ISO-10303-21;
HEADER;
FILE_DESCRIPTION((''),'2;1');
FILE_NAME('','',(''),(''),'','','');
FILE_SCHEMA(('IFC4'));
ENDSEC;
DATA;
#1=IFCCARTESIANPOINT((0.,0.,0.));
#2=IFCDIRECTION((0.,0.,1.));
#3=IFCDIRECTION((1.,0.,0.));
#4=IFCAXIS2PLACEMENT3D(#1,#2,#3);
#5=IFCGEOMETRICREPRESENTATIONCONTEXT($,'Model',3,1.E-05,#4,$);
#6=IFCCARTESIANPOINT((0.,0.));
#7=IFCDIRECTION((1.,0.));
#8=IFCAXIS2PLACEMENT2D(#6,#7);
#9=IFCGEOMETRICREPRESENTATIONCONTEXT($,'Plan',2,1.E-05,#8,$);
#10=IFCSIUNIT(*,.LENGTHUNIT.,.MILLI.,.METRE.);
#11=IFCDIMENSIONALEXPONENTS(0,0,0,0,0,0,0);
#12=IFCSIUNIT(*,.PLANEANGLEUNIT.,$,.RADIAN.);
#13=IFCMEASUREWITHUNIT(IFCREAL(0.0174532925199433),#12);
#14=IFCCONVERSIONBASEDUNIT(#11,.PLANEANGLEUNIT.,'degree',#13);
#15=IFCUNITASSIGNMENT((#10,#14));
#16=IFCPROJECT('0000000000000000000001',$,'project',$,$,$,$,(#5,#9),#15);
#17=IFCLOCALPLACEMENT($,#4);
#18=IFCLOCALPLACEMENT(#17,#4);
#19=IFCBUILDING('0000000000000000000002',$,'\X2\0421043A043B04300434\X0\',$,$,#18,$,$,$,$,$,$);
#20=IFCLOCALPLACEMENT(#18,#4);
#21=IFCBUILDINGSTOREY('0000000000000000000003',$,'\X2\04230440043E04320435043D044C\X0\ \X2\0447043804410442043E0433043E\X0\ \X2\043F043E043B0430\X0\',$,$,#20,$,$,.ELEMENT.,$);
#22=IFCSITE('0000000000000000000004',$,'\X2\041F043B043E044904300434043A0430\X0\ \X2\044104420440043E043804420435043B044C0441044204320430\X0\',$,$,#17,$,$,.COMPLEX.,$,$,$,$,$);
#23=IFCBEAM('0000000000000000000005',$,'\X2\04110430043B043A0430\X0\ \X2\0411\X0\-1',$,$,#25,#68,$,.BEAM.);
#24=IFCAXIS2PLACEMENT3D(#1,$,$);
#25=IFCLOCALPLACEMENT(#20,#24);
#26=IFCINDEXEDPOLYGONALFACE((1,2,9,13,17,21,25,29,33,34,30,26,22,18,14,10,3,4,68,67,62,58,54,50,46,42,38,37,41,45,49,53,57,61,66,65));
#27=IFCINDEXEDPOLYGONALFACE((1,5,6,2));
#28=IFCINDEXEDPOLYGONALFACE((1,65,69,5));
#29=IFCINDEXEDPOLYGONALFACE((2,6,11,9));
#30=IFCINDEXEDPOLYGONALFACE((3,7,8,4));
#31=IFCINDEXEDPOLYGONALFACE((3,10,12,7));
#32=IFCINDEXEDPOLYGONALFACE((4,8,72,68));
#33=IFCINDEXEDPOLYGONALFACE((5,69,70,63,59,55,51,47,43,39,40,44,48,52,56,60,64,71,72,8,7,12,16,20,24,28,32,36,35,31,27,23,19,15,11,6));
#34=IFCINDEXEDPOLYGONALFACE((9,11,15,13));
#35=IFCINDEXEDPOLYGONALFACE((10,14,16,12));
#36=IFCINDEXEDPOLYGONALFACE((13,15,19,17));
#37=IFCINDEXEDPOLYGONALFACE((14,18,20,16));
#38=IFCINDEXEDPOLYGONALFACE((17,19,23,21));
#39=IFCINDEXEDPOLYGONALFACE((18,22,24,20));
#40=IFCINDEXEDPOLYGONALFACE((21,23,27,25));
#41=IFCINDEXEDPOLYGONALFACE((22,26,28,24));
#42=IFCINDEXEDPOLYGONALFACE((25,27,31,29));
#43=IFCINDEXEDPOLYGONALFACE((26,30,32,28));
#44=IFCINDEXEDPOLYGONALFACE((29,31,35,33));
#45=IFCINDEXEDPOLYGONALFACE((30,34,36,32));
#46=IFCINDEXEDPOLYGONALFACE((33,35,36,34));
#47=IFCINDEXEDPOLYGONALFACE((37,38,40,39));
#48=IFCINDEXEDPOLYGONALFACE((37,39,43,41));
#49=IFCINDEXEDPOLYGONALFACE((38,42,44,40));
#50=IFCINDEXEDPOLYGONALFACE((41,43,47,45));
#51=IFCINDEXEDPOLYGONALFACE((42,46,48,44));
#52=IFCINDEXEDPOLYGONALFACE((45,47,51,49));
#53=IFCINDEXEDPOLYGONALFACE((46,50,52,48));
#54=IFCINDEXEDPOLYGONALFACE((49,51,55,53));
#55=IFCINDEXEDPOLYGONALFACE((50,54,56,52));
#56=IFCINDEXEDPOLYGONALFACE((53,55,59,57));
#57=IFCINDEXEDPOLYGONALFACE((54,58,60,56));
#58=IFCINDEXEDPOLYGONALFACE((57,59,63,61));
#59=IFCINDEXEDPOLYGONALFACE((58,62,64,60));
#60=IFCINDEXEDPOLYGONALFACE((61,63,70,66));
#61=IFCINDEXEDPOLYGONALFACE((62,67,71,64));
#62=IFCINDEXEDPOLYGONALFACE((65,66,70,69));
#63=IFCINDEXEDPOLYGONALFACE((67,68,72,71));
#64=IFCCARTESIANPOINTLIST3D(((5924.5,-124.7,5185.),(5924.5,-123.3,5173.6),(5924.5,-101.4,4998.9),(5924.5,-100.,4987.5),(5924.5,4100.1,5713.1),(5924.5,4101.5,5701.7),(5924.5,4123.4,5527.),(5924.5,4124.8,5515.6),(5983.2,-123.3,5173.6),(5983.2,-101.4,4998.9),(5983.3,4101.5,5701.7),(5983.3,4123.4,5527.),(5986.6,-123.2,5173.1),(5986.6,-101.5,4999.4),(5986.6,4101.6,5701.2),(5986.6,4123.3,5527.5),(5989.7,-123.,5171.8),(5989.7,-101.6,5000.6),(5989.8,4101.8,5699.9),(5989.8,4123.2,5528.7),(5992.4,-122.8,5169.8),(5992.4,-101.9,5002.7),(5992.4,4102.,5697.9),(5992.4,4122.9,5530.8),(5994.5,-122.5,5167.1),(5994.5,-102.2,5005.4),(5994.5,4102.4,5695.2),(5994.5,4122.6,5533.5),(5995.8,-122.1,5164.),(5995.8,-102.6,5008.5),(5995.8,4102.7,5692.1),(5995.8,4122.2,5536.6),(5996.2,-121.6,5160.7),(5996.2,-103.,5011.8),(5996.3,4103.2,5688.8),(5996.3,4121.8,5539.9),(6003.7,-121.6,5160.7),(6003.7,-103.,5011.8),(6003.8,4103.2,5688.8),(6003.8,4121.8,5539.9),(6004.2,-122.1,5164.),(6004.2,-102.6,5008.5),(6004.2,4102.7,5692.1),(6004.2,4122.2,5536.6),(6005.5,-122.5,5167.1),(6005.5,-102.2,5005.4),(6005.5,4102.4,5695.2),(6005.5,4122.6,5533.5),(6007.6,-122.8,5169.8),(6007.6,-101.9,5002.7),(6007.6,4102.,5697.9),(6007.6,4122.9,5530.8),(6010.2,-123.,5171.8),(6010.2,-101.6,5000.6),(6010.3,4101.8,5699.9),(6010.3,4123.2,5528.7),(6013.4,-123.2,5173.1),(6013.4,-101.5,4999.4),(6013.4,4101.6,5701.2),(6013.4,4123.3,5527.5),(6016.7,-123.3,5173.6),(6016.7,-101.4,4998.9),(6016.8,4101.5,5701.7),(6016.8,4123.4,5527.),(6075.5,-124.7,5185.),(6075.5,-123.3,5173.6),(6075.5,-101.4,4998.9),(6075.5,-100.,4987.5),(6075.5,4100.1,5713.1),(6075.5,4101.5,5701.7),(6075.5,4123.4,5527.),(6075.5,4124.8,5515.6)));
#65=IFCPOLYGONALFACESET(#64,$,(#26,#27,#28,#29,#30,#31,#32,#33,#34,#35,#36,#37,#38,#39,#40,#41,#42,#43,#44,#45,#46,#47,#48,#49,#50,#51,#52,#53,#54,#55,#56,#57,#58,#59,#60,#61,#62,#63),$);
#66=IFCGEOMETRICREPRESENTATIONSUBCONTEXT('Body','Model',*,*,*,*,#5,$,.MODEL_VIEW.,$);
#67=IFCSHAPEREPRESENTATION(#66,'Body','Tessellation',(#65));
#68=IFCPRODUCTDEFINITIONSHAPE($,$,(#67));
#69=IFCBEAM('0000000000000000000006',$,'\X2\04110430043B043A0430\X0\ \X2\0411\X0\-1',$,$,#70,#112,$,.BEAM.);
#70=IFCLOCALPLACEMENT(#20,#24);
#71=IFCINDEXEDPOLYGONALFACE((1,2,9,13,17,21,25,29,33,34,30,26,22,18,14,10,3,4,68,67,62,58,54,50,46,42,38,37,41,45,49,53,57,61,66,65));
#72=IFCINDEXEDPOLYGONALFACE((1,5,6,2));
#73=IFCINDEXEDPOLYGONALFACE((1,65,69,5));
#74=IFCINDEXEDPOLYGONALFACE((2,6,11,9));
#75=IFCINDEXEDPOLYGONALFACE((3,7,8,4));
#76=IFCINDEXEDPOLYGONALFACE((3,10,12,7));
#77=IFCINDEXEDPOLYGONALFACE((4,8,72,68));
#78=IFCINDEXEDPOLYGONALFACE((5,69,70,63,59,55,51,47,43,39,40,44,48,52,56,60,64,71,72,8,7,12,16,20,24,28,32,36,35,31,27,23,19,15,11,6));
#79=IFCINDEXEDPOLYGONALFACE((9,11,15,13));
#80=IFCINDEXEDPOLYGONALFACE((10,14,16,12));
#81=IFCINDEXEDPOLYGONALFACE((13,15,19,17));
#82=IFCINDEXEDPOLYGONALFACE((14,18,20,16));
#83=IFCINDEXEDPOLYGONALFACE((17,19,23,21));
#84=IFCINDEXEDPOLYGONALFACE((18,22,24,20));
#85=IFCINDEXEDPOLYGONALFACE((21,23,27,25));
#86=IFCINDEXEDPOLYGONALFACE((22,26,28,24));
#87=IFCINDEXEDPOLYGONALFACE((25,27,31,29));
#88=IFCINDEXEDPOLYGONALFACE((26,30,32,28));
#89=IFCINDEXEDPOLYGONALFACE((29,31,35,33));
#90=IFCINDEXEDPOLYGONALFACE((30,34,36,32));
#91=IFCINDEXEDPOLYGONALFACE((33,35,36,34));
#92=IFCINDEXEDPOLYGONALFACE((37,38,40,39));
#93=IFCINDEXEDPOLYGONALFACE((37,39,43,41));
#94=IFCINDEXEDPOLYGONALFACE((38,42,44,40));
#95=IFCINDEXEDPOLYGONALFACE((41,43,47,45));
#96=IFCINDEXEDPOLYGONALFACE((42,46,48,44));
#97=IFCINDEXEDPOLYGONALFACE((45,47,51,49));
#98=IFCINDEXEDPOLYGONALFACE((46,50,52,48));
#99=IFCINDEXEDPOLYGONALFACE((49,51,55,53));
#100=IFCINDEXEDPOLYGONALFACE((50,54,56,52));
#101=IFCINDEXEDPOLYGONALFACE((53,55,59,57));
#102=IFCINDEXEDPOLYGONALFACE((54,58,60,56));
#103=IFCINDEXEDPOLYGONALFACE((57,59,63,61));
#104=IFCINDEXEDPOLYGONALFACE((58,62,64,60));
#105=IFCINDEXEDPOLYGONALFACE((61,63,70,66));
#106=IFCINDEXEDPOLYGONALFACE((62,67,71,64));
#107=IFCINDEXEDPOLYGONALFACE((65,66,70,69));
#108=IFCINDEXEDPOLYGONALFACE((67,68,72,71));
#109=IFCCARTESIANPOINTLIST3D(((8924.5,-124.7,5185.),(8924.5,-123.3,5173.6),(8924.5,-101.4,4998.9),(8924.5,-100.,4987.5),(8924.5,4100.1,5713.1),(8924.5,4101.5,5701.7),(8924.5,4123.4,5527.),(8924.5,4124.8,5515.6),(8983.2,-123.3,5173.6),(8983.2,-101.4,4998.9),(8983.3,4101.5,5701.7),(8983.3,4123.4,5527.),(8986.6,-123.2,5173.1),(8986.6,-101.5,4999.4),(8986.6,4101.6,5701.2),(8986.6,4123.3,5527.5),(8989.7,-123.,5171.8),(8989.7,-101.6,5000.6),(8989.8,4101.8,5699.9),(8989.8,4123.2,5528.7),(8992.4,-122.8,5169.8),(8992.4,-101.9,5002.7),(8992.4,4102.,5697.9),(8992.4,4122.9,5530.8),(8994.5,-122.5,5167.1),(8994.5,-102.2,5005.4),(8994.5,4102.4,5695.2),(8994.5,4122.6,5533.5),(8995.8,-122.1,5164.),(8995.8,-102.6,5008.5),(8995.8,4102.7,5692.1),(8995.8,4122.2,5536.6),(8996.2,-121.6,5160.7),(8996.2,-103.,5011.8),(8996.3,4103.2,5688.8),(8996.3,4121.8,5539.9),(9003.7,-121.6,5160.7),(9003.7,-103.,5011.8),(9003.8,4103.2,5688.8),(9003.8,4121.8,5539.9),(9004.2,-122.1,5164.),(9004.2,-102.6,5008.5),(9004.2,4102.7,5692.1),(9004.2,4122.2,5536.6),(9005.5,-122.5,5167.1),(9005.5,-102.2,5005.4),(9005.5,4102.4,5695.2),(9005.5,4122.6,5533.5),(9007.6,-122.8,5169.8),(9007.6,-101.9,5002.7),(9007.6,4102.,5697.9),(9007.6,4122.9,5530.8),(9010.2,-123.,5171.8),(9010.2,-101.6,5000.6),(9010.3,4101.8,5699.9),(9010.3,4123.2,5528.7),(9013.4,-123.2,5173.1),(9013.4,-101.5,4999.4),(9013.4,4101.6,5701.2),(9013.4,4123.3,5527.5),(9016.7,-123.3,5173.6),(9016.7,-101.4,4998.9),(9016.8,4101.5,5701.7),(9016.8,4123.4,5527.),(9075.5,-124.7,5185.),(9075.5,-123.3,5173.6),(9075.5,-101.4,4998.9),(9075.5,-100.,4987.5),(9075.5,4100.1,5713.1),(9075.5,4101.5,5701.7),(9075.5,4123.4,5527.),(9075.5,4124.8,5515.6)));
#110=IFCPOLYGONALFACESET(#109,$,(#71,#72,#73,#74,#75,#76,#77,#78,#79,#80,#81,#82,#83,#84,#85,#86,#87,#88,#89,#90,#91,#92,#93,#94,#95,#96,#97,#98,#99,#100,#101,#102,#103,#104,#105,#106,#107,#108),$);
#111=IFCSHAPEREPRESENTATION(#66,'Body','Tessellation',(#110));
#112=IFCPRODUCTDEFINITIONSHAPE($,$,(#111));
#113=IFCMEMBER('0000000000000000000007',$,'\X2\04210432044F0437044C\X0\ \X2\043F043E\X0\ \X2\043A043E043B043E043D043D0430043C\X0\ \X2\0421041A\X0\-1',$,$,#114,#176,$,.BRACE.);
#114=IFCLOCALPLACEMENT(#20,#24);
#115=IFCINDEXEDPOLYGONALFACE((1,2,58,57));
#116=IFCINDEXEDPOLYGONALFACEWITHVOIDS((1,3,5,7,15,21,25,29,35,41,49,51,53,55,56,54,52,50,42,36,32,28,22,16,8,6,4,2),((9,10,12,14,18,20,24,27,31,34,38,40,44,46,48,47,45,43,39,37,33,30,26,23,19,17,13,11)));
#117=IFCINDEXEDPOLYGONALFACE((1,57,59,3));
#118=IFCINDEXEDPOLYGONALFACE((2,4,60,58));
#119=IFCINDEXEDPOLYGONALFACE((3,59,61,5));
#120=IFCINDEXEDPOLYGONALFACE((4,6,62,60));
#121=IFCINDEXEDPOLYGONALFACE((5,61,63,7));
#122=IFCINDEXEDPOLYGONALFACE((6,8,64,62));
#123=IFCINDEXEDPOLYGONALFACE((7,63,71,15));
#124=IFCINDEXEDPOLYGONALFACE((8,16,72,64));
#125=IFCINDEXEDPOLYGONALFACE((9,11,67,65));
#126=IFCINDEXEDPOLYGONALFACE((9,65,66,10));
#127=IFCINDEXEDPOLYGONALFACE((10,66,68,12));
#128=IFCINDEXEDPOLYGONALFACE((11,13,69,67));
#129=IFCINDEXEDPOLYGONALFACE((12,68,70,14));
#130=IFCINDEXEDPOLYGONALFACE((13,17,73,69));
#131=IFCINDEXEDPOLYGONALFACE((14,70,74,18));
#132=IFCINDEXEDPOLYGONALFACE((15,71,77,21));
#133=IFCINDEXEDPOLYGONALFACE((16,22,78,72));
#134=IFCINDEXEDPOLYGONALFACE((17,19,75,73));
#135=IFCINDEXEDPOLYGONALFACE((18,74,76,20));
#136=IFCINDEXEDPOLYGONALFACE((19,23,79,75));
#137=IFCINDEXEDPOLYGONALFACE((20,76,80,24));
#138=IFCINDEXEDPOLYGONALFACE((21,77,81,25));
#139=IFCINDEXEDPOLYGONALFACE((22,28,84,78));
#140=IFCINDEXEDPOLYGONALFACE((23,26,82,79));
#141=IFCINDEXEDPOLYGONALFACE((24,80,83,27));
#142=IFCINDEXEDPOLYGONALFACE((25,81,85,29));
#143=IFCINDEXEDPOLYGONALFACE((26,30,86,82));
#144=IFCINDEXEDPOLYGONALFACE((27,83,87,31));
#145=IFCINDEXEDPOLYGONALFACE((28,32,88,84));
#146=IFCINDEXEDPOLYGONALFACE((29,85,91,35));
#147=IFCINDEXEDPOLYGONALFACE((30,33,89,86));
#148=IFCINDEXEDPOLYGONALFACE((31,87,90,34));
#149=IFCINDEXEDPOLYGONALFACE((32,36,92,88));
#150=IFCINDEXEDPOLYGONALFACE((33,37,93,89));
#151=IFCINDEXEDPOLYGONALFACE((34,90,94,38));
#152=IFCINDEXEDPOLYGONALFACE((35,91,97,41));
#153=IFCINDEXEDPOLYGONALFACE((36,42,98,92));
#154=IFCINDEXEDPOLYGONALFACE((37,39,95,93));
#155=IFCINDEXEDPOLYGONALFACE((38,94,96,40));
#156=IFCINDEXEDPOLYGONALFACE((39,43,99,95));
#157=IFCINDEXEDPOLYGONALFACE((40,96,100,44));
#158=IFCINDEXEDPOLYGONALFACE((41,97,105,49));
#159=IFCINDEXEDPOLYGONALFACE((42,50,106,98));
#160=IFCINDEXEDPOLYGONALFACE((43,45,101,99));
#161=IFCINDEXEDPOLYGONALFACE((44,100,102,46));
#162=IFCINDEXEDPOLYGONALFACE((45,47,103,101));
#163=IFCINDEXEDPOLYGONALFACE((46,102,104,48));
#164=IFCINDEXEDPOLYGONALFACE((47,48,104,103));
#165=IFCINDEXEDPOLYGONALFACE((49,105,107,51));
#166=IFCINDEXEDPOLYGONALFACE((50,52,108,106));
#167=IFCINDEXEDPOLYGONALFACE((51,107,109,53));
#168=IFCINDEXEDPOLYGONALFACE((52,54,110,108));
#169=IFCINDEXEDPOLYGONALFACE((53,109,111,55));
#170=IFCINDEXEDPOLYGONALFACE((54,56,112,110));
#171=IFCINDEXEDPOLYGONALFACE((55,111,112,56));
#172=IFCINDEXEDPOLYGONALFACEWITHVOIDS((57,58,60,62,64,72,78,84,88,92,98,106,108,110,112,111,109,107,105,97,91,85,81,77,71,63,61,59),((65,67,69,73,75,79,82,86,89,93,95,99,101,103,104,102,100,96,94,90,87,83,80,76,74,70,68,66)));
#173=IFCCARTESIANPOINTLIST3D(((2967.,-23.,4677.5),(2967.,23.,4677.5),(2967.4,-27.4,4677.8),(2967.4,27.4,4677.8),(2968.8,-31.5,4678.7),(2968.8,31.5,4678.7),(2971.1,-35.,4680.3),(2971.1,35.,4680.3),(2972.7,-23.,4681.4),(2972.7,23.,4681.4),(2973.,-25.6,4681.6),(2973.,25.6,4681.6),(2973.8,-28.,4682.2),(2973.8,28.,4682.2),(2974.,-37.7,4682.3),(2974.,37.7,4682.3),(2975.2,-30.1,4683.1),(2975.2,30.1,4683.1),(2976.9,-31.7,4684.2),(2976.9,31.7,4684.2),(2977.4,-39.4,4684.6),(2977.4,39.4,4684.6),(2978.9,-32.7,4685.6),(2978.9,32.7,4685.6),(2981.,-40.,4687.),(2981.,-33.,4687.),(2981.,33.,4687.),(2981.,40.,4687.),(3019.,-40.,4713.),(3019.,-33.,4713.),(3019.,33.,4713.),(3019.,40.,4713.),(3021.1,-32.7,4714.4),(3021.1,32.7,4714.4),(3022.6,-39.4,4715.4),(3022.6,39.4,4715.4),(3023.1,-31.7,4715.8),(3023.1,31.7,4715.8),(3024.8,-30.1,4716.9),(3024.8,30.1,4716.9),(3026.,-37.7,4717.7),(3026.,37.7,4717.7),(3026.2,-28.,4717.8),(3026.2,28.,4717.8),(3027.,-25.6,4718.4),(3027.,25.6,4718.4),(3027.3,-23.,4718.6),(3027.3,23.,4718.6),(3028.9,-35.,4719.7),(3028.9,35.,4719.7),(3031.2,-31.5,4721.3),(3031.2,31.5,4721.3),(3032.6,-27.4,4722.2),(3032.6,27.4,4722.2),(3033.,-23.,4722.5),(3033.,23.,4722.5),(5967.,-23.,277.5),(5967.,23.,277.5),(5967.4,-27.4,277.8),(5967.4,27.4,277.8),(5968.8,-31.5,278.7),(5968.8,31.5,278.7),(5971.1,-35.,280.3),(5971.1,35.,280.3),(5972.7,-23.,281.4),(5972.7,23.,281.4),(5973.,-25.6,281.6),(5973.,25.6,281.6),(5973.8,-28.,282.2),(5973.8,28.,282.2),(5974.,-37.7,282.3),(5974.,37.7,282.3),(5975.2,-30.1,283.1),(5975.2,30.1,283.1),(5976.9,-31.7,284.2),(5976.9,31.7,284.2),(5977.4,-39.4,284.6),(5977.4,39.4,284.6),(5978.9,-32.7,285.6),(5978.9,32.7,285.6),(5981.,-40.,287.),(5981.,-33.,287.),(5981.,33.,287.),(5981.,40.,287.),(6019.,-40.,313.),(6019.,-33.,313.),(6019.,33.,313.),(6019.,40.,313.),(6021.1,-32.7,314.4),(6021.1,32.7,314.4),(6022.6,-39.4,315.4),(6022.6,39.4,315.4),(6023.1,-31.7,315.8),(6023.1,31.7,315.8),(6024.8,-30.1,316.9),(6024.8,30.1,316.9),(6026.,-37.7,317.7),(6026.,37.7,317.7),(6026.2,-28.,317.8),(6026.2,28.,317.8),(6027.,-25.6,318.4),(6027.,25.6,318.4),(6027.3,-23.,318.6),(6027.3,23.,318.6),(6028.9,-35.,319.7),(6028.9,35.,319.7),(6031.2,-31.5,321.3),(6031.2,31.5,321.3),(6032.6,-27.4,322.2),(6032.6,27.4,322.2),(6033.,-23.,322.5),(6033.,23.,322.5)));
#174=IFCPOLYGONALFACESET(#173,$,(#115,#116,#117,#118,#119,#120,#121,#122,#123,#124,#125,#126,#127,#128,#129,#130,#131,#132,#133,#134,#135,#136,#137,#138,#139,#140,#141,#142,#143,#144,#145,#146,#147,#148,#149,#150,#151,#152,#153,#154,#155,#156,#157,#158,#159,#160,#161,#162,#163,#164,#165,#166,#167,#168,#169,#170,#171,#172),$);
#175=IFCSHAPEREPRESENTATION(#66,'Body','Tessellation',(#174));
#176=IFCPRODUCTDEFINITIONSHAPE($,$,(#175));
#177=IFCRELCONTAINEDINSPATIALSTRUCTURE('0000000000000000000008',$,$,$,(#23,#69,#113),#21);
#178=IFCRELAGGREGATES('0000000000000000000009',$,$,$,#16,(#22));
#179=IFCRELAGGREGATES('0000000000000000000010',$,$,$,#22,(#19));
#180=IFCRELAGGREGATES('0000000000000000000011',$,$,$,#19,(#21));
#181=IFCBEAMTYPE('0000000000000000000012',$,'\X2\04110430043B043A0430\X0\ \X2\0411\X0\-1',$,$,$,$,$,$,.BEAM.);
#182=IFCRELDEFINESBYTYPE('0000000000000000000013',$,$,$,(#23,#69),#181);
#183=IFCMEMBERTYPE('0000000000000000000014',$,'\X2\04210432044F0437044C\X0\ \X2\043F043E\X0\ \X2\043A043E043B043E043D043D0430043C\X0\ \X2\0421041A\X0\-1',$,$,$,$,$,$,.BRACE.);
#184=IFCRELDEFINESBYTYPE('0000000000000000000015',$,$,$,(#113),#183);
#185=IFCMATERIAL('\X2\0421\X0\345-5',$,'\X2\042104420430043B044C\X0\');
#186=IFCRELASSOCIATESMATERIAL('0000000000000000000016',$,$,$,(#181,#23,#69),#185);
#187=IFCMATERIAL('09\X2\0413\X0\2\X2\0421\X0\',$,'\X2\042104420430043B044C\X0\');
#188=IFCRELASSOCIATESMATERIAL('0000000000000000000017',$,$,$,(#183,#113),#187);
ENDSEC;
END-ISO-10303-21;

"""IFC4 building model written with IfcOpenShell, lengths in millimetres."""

from ifc_helpers import new_model, entity, si_unit, converted_unit, frame, origin_with_axes, origin_2d_with_axis, place, context, subcontext, project, spatial, hollow_rectangle, i_section, extrude, material, material_profile, profile_set, profile_usage, type_object, element, save


model = new_model("IFC4")

# Units and contexts
model_context = context("Model", 3, precision=1e-05, world=origin_with_axes())
plan_context = context("Plan", 2, precision=1e-05, world=origin_2d_with_axis())
body_context = subcontext(model_context, "Body", "Model", "MODEL_VIEW")
ifc_project = project(units=[si_unit("LENGTHUNIT", "METRE", prefix="MILLI"), converted_unit("PLANEANGLEUNIT", "degree", entity("IfcReal", 0.0174532925199433), si_unit("PLANEANGLEUNIT", "RADIAN"), dimensions=[0, 0, 0, 0, 0, 0, 0])], contexts=[model_context, plan_context])

# Site, building, storey
site_placement = place(None, origin_with_axes())
site = spatial("IfcSite", under=ifc_project, at=site_placement, Name="Площадка строительства", CompositionType="COMPLEX")
building_placement = place(site_placement, origin_with_axes())
building = spatial("IfcBuilding", under=site, at=building_placement, Name="Склад")
storey_placement = place(building_placement, origin_with_axes())
storey = spatial("IfcBuildingStorey", under=building, at=storey_placement, Name="Уровень чистого пола", CompositionType="ELEMENT")

# Shared definitions
ifc_material_1 = material(Name="С345-5", Category="Сталь")

# Beams
ifc_material_profile_1 = material_profile(ifc_material_1, i_section(OverallWidth=151.0, OverallDepth=199.0, WebThickness=7.5, FlangeThickness=11.5, FilletRadius=13.0, FlangeEdgeRadius=0.0, FlangeSlope=0.0))
ifc_profile_set_1 = profile_set([ifc_material_profile_1], Name="I20H2_S345-5")
ifc_profile_usage_1 = profile_usage(ifc_profile_set_1, cardinal=2)
beam_type_1 = type_object("IfcBeamType", Name="Балка Б-1", PredefinedType="BEAM", material=ifc_profile_set_1)
beam_1_placement = place(storey_placement, frame((6000.0, -100.0, 4987.5), z_axis=(0.0, 0.992278, 0.124035), x_axis=(-1.0, 0.0, 0.0)))
element("IfcBeam", 1, at=beam_1_placement, inside=storey, type_object=beam_type_1, material=ifc_profile_usage_1, Name="Балка Б-1", PredefinedType="BEAM", context=body_context, shape_type="SweptSolid", body=[
    extrude(i_section(OverallWidth=151.0, OverallDepth=199.0, WebThickness=7.5, FlangeThickness=11.5, FilletRadius=13.0, FlangeEdgeRadius=0.0, FlangeSlope=0.0), frame((0.0, 99.5, 0.0), z_axis=(0.0, 0.0, 1.0), x_axis=(1.0, 0.0, 0.0)), (0.0, 0.0, 1.0), 4257.7),
])
beam_2_placement = place(storey_placement, frame((9000.0, -100.0, 4987.5), z_axis=(0.0, 0.992278, 0.124035), x_axis=(-1.0, 0.0, 0.0)))
element("IfcBeam", 2, at=beam_2_placement, inside=storey, type_object=beam_type_1, material=ifc_profile_usage_1, Name="Балка Б-1", PredefinedType="BEAM", context=body_context, shape_type="SweptSolid", body=[
    extrude(i_section(OverallWidth=151.0, OverallDepth=199.0, WebThickness=7.5, FlangeThickness=11.5, FilletRadius=13.0, FlangeEdgeRadius=0.0, FlangeSlope=0.0), frame((0.0, 99.5, 0.0), z_axis=(0.0, 0.0, 1.0), x_axis=(1.0, 0.0, 0.0)), (0.0, 0.0, 1.0), 4257.7),
])

# Member
ifc_material_2 = material(Name="09Г2С", Category="Сталь")
ifc_material_profile_2 = material_profile(ifc_material_2, hollow_rectangle(XDim=80.0, YDim=80.0, WallThickness=7.0, InnerFilletRadius=10.0, OuterFilletRadius=17.0))
ifc_profile_set_2 = profile_set([ifc_material_profile_2], Name="PK80x7_09G2S")
ifc_profile_usage_2 = profile_usage(ifc_profile_set_2, cardinal=5)
member_type_1 = type_object("IfcMemberType", Name="Связь по колоннам СК-1", PredefinedType="BRACE", material=ifc_profile_set_2)
member_1_placement = place(storey_placement, frame((6000.0, 0.0, 300.0), z_axis=(-0.563337, 0.0, 0.826227), x_axis=(0.0, -1.0, 0.0)))
element("IfcMember", 3, at=member_1_placement, inside=storey, type_object=member_type_1, material=ifc_profile_usage_2, Name="Связь по колоннам СК-1", PredefinedType="BRACE", context=body_context, shape_type="Clipping", body=[
    extrude(hollow_rectangle(XDim=80.0, YDim=80.0, WallThickness=7.0, InnerFilletRadius=10.0, OuterFilletRadius=17.0), origin_with_axes(), (0.0, 0.0, 1.0), 5325.4),
])

save(model, "model.ifc")
